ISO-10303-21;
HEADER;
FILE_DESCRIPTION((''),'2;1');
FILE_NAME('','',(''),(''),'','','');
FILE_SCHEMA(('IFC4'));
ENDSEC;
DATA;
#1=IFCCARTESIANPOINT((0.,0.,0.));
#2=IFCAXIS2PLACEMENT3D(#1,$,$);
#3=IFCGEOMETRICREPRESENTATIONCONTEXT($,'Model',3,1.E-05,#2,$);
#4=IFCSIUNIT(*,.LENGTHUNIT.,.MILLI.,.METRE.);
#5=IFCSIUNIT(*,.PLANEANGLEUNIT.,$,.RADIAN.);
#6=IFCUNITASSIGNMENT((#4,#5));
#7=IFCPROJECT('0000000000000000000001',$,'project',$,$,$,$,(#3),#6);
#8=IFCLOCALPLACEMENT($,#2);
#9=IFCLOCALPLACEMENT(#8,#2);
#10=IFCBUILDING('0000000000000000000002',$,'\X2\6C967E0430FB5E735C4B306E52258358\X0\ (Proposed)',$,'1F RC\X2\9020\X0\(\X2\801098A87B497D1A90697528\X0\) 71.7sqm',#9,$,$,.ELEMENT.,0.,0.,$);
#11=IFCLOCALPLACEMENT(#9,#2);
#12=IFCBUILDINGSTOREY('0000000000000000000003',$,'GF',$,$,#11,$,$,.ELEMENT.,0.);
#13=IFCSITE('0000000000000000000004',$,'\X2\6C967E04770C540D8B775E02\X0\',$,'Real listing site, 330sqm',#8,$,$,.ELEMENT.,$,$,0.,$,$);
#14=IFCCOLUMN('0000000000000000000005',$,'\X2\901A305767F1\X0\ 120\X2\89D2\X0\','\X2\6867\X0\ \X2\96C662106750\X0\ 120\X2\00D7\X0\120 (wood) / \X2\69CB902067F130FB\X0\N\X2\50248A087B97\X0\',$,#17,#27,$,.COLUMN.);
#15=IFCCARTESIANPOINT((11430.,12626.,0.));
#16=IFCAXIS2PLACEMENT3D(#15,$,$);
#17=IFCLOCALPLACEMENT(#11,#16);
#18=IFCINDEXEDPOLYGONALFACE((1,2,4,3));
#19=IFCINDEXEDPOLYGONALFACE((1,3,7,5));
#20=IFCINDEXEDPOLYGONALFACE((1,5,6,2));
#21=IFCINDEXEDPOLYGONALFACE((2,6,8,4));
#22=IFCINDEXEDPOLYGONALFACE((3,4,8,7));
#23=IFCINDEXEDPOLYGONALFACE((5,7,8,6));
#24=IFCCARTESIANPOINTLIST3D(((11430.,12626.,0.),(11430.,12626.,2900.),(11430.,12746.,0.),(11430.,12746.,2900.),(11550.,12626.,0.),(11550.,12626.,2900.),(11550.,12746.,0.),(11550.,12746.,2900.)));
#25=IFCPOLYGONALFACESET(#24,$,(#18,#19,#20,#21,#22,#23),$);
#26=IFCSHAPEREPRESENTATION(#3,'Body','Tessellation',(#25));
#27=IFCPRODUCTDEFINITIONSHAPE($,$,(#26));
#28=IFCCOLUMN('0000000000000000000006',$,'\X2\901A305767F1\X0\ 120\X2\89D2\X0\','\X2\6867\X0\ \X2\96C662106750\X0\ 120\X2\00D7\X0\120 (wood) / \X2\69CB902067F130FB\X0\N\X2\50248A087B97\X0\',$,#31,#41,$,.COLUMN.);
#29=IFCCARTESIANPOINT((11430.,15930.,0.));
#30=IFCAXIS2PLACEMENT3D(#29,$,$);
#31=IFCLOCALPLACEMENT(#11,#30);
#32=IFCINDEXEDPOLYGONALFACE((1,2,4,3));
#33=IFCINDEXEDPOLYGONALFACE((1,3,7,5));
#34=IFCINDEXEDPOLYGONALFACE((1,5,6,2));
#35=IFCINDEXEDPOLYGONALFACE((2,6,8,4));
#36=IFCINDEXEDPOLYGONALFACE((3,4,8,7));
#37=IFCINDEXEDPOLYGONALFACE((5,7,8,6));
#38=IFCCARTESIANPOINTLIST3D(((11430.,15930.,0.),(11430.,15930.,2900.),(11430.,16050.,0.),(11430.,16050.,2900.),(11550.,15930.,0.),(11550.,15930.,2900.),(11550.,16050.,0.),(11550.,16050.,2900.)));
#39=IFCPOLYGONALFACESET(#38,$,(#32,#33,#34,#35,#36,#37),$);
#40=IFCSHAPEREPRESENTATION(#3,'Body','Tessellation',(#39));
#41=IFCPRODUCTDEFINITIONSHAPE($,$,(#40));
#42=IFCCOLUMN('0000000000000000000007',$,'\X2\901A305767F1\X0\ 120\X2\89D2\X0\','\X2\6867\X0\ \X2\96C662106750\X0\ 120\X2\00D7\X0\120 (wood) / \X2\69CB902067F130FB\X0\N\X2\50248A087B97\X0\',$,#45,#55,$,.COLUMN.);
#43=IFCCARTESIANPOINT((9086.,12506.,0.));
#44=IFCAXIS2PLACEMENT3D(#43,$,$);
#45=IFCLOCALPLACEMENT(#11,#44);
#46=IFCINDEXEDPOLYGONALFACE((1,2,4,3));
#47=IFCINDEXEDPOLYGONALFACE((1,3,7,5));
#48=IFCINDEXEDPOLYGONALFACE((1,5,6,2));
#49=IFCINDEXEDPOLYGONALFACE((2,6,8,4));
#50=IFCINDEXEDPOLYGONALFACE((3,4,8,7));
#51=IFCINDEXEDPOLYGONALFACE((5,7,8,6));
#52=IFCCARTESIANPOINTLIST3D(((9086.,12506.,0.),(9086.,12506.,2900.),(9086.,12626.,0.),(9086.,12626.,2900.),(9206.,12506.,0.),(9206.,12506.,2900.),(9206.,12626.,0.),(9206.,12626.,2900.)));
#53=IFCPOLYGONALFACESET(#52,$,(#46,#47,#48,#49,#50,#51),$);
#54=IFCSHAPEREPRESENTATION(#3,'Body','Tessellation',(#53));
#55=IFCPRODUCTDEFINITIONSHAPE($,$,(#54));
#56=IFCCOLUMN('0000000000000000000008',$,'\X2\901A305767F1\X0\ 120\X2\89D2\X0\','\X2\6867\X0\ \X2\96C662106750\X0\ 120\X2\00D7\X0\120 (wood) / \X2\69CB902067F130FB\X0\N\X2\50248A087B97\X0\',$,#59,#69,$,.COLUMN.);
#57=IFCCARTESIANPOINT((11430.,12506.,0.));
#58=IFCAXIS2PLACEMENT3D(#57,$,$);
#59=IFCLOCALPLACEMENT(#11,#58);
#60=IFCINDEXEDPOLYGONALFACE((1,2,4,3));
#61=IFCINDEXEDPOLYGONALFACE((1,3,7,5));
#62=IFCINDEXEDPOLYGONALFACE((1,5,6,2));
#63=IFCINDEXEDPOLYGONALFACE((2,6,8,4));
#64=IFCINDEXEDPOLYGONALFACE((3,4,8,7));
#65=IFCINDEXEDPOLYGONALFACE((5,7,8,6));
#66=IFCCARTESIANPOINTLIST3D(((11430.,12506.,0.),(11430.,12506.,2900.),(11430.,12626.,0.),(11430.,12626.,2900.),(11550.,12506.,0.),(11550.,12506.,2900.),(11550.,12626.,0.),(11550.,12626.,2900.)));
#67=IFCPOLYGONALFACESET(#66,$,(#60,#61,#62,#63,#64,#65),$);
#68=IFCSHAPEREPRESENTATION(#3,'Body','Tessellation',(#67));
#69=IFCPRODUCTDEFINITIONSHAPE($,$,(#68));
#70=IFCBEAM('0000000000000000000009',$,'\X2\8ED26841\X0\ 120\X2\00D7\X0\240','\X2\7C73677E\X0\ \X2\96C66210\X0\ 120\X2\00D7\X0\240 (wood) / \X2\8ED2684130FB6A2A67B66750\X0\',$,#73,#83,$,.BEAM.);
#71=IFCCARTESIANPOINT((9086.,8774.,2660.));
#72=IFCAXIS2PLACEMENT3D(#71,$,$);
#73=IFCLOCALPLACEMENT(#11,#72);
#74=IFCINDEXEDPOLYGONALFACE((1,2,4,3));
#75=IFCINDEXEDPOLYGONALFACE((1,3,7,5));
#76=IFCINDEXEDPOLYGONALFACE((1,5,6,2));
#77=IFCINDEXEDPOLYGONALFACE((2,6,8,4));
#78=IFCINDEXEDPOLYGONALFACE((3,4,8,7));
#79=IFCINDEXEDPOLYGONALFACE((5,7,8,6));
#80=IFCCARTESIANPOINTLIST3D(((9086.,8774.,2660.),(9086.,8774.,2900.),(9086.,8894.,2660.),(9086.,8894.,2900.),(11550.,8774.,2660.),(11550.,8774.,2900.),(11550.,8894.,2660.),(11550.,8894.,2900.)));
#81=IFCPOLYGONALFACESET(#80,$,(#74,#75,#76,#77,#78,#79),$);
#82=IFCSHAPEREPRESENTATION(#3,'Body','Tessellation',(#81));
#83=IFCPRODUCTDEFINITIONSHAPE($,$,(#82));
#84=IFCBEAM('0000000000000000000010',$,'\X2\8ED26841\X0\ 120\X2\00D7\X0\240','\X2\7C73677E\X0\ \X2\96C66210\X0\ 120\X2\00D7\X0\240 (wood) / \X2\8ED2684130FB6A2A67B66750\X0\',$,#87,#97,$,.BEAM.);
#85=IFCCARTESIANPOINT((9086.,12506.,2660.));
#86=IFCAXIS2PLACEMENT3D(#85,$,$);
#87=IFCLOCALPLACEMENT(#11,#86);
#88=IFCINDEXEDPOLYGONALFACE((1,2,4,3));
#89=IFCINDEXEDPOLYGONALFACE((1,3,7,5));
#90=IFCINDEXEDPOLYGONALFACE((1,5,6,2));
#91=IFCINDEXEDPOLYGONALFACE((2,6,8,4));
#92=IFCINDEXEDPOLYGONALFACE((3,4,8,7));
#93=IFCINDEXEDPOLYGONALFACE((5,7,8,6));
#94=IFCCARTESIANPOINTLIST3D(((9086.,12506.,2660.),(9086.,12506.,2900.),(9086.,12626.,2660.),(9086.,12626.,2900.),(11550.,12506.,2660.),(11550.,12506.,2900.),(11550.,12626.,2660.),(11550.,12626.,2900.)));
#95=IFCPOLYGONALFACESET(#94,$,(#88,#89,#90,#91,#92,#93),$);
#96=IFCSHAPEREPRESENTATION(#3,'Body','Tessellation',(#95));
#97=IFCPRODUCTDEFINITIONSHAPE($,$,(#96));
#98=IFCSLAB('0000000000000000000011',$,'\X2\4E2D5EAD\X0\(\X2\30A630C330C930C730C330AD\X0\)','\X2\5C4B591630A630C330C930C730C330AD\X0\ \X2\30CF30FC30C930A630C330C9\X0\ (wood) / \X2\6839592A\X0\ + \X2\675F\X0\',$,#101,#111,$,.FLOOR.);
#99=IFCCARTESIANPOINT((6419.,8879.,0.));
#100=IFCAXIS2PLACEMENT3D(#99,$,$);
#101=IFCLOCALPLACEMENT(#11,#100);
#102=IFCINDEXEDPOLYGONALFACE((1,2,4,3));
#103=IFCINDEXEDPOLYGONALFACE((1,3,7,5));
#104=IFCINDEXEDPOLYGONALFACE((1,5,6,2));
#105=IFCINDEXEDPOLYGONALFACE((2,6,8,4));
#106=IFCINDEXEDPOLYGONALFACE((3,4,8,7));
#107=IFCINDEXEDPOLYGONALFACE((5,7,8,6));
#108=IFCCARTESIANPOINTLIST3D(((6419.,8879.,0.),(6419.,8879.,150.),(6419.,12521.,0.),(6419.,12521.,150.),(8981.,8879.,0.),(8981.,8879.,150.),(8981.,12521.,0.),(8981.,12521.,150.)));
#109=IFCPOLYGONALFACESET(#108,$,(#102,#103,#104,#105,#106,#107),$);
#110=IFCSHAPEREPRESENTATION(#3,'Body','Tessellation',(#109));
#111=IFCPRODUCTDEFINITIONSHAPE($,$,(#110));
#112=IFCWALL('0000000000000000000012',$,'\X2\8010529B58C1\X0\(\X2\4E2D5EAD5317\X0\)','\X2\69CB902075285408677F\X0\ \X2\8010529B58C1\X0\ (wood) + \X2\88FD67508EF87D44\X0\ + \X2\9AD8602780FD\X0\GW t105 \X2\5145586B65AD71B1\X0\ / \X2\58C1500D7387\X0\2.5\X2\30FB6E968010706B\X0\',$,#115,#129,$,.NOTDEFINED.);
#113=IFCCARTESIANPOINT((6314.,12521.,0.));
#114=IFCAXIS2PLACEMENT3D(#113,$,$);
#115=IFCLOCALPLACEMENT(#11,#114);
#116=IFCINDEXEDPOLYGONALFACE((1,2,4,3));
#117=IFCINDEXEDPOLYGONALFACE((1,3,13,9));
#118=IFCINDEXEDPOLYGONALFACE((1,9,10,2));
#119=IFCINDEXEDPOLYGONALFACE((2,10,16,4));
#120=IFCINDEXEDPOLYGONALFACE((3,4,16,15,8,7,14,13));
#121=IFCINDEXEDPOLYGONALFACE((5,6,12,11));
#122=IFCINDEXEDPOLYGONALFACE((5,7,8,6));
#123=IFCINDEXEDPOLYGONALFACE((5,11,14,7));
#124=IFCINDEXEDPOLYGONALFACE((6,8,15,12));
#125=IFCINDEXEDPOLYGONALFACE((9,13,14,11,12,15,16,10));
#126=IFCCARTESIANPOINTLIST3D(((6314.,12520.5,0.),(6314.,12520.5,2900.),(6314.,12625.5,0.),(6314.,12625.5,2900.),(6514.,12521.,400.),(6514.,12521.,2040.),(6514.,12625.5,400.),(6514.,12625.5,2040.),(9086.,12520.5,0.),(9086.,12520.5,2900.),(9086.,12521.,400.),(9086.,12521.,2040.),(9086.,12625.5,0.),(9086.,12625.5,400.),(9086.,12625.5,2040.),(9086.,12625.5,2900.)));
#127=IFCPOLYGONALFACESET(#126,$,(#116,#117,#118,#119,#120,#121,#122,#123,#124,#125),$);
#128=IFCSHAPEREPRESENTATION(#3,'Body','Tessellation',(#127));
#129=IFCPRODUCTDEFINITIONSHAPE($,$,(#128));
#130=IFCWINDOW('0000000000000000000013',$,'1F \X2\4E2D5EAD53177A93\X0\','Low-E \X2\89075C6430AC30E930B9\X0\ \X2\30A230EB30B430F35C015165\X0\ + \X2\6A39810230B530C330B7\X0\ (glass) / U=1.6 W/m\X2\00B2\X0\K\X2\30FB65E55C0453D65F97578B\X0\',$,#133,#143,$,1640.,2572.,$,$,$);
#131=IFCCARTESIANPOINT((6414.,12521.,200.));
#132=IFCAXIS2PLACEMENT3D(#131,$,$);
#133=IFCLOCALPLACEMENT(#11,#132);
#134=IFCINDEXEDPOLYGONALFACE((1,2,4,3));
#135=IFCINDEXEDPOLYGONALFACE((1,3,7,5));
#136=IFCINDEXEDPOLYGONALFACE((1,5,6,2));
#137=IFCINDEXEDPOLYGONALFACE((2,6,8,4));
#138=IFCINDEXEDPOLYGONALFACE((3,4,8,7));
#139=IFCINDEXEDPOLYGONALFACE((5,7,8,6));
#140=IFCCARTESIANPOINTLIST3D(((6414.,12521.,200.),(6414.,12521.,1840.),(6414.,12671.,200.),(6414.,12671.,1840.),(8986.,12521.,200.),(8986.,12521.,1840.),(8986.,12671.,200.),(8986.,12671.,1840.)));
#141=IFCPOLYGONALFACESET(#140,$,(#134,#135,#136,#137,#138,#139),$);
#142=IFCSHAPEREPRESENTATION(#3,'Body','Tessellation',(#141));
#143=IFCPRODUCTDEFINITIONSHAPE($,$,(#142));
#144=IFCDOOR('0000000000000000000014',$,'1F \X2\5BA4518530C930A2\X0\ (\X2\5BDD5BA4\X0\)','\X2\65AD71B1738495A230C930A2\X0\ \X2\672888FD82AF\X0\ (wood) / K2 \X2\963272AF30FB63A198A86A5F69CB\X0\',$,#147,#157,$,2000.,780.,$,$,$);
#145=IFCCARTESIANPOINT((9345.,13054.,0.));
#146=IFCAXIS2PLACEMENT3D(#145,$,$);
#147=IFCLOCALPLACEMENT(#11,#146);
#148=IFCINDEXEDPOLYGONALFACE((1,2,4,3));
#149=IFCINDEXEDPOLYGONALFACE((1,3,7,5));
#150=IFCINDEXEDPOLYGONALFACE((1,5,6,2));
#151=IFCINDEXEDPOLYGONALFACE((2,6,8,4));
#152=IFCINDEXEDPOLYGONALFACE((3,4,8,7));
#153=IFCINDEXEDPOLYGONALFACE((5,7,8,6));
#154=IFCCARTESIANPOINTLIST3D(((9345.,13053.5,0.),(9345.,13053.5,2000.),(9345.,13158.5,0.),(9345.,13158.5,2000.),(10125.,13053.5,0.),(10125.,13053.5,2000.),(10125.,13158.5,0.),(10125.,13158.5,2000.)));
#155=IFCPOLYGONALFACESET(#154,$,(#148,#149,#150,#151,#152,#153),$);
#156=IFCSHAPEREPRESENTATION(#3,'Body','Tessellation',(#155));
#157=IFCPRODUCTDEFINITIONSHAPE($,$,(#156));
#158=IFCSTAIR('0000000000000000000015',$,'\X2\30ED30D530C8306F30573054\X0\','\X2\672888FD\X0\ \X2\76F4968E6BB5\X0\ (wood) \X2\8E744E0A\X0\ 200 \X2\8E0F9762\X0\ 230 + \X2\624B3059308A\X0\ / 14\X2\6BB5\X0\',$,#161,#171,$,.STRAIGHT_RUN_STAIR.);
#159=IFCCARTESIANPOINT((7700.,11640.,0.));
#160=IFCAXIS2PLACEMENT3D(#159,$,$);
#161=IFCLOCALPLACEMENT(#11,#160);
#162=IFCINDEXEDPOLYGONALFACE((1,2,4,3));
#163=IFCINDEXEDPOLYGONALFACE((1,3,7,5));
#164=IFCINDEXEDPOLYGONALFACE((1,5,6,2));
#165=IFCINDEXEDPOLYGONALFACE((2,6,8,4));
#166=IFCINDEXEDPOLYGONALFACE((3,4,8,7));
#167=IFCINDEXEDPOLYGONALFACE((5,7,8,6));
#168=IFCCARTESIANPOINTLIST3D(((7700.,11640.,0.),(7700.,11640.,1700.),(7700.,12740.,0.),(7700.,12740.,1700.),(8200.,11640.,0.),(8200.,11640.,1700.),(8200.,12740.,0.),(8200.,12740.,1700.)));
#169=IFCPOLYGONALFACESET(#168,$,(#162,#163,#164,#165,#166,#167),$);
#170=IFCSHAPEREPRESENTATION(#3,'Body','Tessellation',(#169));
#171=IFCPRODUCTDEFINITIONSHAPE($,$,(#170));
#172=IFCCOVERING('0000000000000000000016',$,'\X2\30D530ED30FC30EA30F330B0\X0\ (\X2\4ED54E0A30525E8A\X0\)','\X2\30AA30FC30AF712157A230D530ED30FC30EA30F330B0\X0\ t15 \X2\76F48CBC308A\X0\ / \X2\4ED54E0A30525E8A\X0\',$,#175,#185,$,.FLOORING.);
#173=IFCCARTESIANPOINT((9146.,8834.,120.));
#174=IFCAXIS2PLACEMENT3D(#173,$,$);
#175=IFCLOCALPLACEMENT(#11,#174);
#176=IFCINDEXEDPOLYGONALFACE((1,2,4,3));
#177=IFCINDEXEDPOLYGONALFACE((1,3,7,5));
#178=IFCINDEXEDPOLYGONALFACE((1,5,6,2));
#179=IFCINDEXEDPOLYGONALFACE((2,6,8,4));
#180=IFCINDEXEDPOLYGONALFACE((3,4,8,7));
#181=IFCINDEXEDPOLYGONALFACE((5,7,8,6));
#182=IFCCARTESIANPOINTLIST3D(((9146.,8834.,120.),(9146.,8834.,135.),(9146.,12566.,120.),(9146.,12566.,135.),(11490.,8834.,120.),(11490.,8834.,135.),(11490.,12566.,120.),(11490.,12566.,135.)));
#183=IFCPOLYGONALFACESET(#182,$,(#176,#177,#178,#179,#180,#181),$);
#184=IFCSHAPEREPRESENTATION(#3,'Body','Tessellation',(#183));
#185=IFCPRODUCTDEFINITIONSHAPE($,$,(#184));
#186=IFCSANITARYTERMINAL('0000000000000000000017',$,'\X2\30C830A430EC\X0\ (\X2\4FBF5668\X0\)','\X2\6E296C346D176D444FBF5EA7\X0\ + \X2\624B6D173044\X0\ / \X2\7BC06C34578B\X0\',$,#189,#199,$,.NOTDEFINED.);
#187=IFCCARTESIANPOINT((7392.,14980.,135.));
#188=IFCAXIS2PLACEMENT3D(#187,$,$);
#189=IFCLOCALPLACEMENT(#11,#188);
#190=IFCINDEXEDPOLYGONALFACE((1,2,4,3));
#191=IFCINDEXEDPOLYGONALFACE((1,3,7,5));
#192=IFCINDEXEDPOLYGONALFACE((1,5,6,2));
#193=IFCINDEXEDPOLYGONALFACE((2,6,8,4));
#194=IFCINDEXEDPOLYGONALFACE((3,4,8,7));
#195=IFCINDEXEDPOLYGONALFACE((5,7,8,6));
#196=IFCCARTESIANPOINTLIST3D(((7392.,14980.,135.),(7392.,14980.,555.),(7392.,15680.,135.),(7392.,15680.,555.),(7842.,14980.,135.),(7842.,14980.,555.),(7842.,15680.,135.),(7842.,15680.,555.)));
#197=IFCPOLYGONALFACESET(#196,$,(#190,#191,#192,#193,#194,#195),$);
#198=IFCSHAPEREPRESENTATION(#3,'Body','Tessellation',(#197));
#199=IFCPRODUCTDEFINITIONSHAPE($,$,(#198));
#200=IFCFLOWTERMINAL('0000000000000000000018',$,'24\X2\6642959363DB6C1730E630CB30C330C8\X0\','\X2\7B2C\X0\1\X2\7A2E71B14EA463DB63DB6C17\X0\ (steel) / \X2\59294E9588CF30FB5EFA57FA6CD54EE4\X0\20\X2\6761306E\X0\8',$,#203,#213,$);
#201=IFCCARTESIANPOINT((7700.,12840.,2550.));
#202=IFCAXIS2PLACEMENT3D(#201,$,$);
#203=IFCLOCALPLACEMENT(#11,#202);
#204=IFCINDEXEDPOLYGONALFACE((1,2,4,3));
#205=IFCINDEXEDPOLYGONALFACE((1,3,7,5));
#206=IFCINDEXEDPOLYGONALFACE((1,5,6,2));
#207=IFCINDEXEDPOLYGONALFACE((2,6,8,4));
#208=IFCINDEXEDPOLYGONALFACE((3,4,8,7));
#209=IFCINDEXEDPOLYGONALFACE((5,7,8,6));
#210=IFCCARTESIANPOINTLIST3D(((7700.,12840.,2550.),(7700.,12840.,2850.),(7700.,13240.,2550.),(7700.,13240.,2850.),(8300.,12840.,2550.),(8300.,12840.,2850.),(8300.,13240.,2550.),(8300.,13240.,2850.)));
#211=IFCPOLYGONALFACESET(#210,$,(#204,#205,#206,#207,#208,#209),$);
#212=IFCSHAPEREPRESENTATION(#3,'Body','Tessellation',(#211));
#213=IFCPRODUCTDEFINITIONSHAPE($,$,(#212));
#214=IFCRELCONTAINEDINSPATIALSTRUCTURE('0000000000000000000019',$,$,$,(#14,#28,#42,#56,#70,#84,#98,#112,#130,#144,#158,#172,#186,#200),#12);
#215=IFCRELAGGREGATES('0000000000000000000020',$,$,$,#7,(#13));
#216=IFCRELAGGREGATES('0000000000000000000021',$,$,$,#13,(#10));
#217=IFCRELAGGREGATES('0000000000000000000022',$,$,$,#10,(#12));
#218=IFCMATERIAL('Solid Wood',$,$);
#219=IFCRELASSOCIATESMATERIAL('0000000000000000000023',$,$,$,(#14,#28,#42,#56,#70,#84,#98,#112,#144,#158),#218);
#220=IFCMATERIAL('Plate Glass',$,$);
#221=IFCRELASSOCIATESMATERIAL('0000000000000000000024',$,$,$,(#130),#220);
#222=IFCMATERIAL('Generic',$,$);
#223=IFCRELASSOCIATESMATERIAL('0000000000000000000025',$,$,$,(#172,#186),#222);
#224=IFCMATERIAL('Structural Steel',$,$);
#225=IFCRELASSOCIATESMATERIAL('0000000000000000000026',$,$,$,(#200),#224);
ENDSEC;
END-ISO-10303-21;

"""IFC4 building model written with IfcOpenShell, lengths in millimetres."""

from ifc_helpers import new_model, si_unit, frame, frame_2d, origin, place, context, project, spatial, rectangle, extrude, material, element, fill, save


model = new_model("IFC4")

# Units and contexts
model_context = context("Model", 3, precision=1e-05, world=origin())
ifc_project = project(units=[si_unit("LENGTHUNIT", "METRE", prefix="MILLI"), si_unit("PLANEANGLEUNIT", "RADIAN")], contexts=[model_context])

# Site, building, storey
site_placement = place(None, origin())
site = spatial("IfcSite", under=ifc_project, at=site_placement, Name="沖縄県名護市", ObjectType="Real listing site, 330sqm", CompositionType="ELEMENT", RefElevation=0.0)
building_placement = place(site_placement, origin())
building = spatial("IfcBuilding", under=site, at=building_placement, Name="沖縄・平屋の別荘 (Proposed)", ObjectType="1F RC造(耐風等級適用) 71.7sqm", CompositionType="ELEMENT", ElevationOfRefHeight=0.0, ElevationOfTerrain=0.0)
storey_placement = place(building_placement, origin())
storey = spatial("IfcBuildingStorey", under=building, at=storey_placement, Name="GF", CompositionType="ELEMENT", Elevation=0.0)

# Columns
ifc_material_1 = material(Name="Solid Wood")
column_1_placement = place(storey_placement, frame((11430.0, 12626.0, 0.0)))
element("IfcColumn", 1, at=column_1_placement, inside=storey, material=ifc_material_1, Name="通し柱 120角", Description="桧 集成材 120×120 (wood) / 構造柱・N値計算", PredefinedType="COLUMN", context=model_context, shape_type="SweptSolid", body=[
    extrude(rectangle(XDim=120.0, YDim=120.0, at=frame_2d((60.0, 60.0))), frame((11430.0, 12626.0, 0.0)), (0.0, 0.0, 1.0), 2900.0),
])
column_2_placement = place(storey_placement, frame((11430.0, 15930.0, 0.0)))
element("IfcColumn", 2, at=column_2_placement, inside=storey, material=ifc_material_1, Name="通し柱 120角", Description="桧 集成材 120×120 (wood) / 構造柱・N値計算", PredefinedType="COLUMN", context=model_context, shape_type="SweptSolid", body=[
    extrude(rectangle(XDim=120.0, YDim=120.0, at=frame_2d((60.0, 60.0))), frame((11430.0, 15930.0, 0.0)), (0.0, 0.0, 1.0), 2900.0),
])
column_3_placement = place(storey_placement, frame((9086.0, 12506.0, 0.0)))
element("IfcColumn", 3, at=column_3_placement, inside=storey, material=ifc_material_1, Name="通し柱 120角", Description="桧 集成材 120×120 (wood) / 構造柱・N値計算", PredefinedType="COLUMN", context=model_context, shape_type="SweptSolid", body=[
    extrude(rectangle(XDim=120.0, YDim=120.0, at=frame_2d((60.0, 60.0))), frame((9086.0, 12506.0, 0.0)), (0.0, 0.0, 1.0), 2900.0),
])
column_4_placement = place(storey_placement, frame((11430.0, 12506.0, 0.0)))
element("IfcColumn", 4, at=column_4_placement, inside=storey, material=ifc_material_1, Name="通し柱 120角", Description="桧 集成材 120×120 (wood) / 構造柱・N値計算", PredefinedType="COLUMN", context=model_context, shape_type="SweptSolid", body=[
    extrude(rectangle(XDim=120.0, YDim=120.0, at=frame_2d((60.0, 60.0))), frame((11430.0, 12506.0, 0.0)), (0.0, 0.0, 1.0), 2900.0),
])

# Beams
beam_1_placement = place(storey_placement, frame((9086.0, 8774.0, 2660.0)))
element("IfcBeam", 5, at=beam_1_placement, inside=storey, material=ifc_material_1, Name="軒桁 120×240", Description="米松 集成 120×240 (wood) / 軒桁・横架材", PredefinedType="BEAM", context=model_context, shape_type="SweptSolid", body=[
    extrude(rectangle(XDim=2464.0, YDim=120.0, at=frame_2d((1232.0, 60.0))), frame((9086.0, 8774.0, 2660.0)), (0.0, 0.0, 1.0), 240.0),
])
beam_2_placement = place(storey_placement, frame((9086.0, 12506.0, 2660.0)))
element("IfcBeam", 6, at=beam_2_placement, inside=storey, material=ifc_material_1, Name="軒桁 120×240", Description="米松 集成 120×240 (wood) / 軒桁・横架材", PredefinedType="BEAM", context=model_context, shape_type="SweptSolid", body=[
    extrude(rectangle(XDim=2464.0, YDim=120.0, at=frame_2d((1232.0, 60.0))), frame((9086.0, 12506.0, 2660.0)), (0.0, 0.0, 1.0), 240.0),
])

# Slab
slab_placement = place(storey_placement, frame((6419.0, 8879.0, 0.0)))
element("IfcSlab", 7, at=slab_placement, inside=storey, material=ifc_material_1, Name="中庭(ウッドデッキ)", Description="屋外ウッドデッキ ハードウッド (wood) / 根太 + 束", PredefinedType="FLOOR", context=model_context, shape_type="SweptSolid", body=[
    extrude(rectangle(XDim=2562.0, YDim=3642.0, at=frame_2d((1281.0, 1821.0))), frame((6419.0, 8879.0, 0.0)), (0.0, 0.0, 1.0), 150.0),
])

# Wall, opening, window
wall_1_placement = place(storey_placement, frame((6314.0, 12521.0, 0.0)))
wall_1 = element("IfcWall", 8, at=wall_1_placement, inside=storey, material=ifc_material_1, Name="耐力壁(中庭北)", Description="構造用合板 耐力壁 (wood) + 製材軸組 + 高性能GW t105 充填断熱 / 壁倍率2.5・準耐火", PredefinedType="NOTDEFINED", context=model_context, shape_type="SweptSolid", body=[
    extrude(rectangle(XDim=2772.0, YDim=105.0, at=frame_2d((1386.0, 52.0))), frame((6314.0, 12521.0, 0.0)), (0.0, 0.0, 1.0), 2900.0),
])
opening_placement = place(storey_placement, frame((6414.0, 12521.0, 200.0)))
opening = element("IfcOpeningElement", 9, at=opening_placement, cuts=wall_1, PredefinedType="NOTDEFINED", context=model_context, shape_type="SweptSolid", body=[
    extrude(rectangle(XDim=2572.0, YDim=150.0, at=frame_2d((1286.0, 75.0))), frame((6414.0, 12521.0, 200.0)), (0.0, 0.0, 1.0), 1640.0),
])
ifc_material_2 = material(Name="Plate Glass")
window_placement = place(storey_placement, frame((6414.0, 12521.0, 200.0)))
window = element("IfcWindow", 10, at=window_placement, inside=storey, material=ifc_material_2, Name="1F 中庭北窓", Description="Low-E 複層ガラス アルゴン封入 + 樹脂サッシ (glass) / U=1.6 W/m²K・日射取得型", OverallHeight=1640.0, OverallWidth=2572.0, context=model_context, shape_type="SweptSolid", body=[
    extrude(rectangle(XDim=2572.0, YDim=150.0, at=frame_2d((1286.0, 75.0))), frame((6414.0, 12521.0, 200.0)), (0.0, 0.0, 1.0), 1640.0),
])
fill(opening, window)

# Door
door_placement = place(storey_placement, frame((9345.0, 13054.0, 0.0)))
element("IfcDoor", 11, at=door_placement, inside=storey, material=ifc_material_1, Name="1F 室内ドア (寝室)", Description="断熱玄関ドア 木製芯 (wood) / K2 防犯・採風機構", OverallHeight=2000.0, OverallWidth=780.0, context=model_context, shape_type="SweptSolid", body=[
    extrude(rectangle(XDim=780.0, YDim=105.0, at=frame_2d((390.0, 52.0))), frame((9345.0, 13054.0, 0.0)), (0.0, 0.0, 1.0), 2000.0),
])

# Stair
stair_placement = place(storey_placement, frame((7700.0, 11640.0, 0.0)))
element("IfcStair", 12, at=stair_placement, inside=storey, material=ifc_material_1, Name="ロフトはしご", Description="木製 直階段 (wood) 蹴上 200 踏面 230 + 手すり / 14段", PredefinedType="STRAIGHT_RUN_STAIR", context=model_context, shape_type="SweptSolid", body=[
    extrude(rectangle(XDim=500.0, YDim=1100.0, at=frame_2d((250.0, 550.0))), frame((7700.0, 11640.0, 0.0)), (0.0, 0.0, 1.0), 1700.0),
])

# Covering
ifc_material_3 = material(Name="Generic")
covering_placement = place(storey_placement, frame((9146.0, 8834.0, 120.0)))
element("IfcCovering", 13, at=covering_placement, inside=storey, material=ifc_material_3, Name="フローリング (仕上げ床)", Description="オーク無垢フローリング t15 直貼り / 仕上げ床", PredefinedType="FLOORING", context=model_context, shape_type="SweptSolid", body=[
    extrude(rectangle(XDim=2344.0, YDim=3732.0, at=frame_2d((1172.0, 1866.0))), frame((9146.0, 8834.0, 120.0)), (0.0, 0.0, 1.0), 15.0),
])

# Sanitary terminal
sanitary_terminal_placement = place(storey_placement, frame((7392.0, 14980.0, 135.0)))
element("IfcSanitaryTerminal", 14, at=sanitary_terminal_placement, inside=storey, material=ifc_material_3, Name="トイレ (便器)", Description="温水洗浄便座 + 手洗い / 節水型", PredefinedType="NOTDEFINED", context=model_context, shape_type="SweptSolid", body=[
    extrude(rectangle(XDim=450.0, YDim=700.0, at=frame_2d((225.0, 350.0))), frame((7392.0, 14980.0, 135.0)), (0.0, 0.0, 1.0), 420.0),
])

# Flow terminal
ifc_material_4 = material(Name="Structural Steel")
flow_terminal_placement = place(storey_placement, frame((7700.0, 12840.0, 2550.0)))
element("IfcFlowTerminal", 15, at=flow_terminal_placement, inside=storey, material=ifc_material_4, Name="24時間換気ユニット", Description="第1種熱交換換気 (steel) / 天井裏・建基法令20条の8", context=model_context, shape_type="SweptSolid", body=[
    extrude(rectangle(XDim=600.0, YDim=400.0, at=frame_2d((300.0, 200.0))), frame((7700.0, 12840.0, 2550.0)), (0.0, 0.0, 1.0), 300.0),
])

save(model, "model.ifc")
